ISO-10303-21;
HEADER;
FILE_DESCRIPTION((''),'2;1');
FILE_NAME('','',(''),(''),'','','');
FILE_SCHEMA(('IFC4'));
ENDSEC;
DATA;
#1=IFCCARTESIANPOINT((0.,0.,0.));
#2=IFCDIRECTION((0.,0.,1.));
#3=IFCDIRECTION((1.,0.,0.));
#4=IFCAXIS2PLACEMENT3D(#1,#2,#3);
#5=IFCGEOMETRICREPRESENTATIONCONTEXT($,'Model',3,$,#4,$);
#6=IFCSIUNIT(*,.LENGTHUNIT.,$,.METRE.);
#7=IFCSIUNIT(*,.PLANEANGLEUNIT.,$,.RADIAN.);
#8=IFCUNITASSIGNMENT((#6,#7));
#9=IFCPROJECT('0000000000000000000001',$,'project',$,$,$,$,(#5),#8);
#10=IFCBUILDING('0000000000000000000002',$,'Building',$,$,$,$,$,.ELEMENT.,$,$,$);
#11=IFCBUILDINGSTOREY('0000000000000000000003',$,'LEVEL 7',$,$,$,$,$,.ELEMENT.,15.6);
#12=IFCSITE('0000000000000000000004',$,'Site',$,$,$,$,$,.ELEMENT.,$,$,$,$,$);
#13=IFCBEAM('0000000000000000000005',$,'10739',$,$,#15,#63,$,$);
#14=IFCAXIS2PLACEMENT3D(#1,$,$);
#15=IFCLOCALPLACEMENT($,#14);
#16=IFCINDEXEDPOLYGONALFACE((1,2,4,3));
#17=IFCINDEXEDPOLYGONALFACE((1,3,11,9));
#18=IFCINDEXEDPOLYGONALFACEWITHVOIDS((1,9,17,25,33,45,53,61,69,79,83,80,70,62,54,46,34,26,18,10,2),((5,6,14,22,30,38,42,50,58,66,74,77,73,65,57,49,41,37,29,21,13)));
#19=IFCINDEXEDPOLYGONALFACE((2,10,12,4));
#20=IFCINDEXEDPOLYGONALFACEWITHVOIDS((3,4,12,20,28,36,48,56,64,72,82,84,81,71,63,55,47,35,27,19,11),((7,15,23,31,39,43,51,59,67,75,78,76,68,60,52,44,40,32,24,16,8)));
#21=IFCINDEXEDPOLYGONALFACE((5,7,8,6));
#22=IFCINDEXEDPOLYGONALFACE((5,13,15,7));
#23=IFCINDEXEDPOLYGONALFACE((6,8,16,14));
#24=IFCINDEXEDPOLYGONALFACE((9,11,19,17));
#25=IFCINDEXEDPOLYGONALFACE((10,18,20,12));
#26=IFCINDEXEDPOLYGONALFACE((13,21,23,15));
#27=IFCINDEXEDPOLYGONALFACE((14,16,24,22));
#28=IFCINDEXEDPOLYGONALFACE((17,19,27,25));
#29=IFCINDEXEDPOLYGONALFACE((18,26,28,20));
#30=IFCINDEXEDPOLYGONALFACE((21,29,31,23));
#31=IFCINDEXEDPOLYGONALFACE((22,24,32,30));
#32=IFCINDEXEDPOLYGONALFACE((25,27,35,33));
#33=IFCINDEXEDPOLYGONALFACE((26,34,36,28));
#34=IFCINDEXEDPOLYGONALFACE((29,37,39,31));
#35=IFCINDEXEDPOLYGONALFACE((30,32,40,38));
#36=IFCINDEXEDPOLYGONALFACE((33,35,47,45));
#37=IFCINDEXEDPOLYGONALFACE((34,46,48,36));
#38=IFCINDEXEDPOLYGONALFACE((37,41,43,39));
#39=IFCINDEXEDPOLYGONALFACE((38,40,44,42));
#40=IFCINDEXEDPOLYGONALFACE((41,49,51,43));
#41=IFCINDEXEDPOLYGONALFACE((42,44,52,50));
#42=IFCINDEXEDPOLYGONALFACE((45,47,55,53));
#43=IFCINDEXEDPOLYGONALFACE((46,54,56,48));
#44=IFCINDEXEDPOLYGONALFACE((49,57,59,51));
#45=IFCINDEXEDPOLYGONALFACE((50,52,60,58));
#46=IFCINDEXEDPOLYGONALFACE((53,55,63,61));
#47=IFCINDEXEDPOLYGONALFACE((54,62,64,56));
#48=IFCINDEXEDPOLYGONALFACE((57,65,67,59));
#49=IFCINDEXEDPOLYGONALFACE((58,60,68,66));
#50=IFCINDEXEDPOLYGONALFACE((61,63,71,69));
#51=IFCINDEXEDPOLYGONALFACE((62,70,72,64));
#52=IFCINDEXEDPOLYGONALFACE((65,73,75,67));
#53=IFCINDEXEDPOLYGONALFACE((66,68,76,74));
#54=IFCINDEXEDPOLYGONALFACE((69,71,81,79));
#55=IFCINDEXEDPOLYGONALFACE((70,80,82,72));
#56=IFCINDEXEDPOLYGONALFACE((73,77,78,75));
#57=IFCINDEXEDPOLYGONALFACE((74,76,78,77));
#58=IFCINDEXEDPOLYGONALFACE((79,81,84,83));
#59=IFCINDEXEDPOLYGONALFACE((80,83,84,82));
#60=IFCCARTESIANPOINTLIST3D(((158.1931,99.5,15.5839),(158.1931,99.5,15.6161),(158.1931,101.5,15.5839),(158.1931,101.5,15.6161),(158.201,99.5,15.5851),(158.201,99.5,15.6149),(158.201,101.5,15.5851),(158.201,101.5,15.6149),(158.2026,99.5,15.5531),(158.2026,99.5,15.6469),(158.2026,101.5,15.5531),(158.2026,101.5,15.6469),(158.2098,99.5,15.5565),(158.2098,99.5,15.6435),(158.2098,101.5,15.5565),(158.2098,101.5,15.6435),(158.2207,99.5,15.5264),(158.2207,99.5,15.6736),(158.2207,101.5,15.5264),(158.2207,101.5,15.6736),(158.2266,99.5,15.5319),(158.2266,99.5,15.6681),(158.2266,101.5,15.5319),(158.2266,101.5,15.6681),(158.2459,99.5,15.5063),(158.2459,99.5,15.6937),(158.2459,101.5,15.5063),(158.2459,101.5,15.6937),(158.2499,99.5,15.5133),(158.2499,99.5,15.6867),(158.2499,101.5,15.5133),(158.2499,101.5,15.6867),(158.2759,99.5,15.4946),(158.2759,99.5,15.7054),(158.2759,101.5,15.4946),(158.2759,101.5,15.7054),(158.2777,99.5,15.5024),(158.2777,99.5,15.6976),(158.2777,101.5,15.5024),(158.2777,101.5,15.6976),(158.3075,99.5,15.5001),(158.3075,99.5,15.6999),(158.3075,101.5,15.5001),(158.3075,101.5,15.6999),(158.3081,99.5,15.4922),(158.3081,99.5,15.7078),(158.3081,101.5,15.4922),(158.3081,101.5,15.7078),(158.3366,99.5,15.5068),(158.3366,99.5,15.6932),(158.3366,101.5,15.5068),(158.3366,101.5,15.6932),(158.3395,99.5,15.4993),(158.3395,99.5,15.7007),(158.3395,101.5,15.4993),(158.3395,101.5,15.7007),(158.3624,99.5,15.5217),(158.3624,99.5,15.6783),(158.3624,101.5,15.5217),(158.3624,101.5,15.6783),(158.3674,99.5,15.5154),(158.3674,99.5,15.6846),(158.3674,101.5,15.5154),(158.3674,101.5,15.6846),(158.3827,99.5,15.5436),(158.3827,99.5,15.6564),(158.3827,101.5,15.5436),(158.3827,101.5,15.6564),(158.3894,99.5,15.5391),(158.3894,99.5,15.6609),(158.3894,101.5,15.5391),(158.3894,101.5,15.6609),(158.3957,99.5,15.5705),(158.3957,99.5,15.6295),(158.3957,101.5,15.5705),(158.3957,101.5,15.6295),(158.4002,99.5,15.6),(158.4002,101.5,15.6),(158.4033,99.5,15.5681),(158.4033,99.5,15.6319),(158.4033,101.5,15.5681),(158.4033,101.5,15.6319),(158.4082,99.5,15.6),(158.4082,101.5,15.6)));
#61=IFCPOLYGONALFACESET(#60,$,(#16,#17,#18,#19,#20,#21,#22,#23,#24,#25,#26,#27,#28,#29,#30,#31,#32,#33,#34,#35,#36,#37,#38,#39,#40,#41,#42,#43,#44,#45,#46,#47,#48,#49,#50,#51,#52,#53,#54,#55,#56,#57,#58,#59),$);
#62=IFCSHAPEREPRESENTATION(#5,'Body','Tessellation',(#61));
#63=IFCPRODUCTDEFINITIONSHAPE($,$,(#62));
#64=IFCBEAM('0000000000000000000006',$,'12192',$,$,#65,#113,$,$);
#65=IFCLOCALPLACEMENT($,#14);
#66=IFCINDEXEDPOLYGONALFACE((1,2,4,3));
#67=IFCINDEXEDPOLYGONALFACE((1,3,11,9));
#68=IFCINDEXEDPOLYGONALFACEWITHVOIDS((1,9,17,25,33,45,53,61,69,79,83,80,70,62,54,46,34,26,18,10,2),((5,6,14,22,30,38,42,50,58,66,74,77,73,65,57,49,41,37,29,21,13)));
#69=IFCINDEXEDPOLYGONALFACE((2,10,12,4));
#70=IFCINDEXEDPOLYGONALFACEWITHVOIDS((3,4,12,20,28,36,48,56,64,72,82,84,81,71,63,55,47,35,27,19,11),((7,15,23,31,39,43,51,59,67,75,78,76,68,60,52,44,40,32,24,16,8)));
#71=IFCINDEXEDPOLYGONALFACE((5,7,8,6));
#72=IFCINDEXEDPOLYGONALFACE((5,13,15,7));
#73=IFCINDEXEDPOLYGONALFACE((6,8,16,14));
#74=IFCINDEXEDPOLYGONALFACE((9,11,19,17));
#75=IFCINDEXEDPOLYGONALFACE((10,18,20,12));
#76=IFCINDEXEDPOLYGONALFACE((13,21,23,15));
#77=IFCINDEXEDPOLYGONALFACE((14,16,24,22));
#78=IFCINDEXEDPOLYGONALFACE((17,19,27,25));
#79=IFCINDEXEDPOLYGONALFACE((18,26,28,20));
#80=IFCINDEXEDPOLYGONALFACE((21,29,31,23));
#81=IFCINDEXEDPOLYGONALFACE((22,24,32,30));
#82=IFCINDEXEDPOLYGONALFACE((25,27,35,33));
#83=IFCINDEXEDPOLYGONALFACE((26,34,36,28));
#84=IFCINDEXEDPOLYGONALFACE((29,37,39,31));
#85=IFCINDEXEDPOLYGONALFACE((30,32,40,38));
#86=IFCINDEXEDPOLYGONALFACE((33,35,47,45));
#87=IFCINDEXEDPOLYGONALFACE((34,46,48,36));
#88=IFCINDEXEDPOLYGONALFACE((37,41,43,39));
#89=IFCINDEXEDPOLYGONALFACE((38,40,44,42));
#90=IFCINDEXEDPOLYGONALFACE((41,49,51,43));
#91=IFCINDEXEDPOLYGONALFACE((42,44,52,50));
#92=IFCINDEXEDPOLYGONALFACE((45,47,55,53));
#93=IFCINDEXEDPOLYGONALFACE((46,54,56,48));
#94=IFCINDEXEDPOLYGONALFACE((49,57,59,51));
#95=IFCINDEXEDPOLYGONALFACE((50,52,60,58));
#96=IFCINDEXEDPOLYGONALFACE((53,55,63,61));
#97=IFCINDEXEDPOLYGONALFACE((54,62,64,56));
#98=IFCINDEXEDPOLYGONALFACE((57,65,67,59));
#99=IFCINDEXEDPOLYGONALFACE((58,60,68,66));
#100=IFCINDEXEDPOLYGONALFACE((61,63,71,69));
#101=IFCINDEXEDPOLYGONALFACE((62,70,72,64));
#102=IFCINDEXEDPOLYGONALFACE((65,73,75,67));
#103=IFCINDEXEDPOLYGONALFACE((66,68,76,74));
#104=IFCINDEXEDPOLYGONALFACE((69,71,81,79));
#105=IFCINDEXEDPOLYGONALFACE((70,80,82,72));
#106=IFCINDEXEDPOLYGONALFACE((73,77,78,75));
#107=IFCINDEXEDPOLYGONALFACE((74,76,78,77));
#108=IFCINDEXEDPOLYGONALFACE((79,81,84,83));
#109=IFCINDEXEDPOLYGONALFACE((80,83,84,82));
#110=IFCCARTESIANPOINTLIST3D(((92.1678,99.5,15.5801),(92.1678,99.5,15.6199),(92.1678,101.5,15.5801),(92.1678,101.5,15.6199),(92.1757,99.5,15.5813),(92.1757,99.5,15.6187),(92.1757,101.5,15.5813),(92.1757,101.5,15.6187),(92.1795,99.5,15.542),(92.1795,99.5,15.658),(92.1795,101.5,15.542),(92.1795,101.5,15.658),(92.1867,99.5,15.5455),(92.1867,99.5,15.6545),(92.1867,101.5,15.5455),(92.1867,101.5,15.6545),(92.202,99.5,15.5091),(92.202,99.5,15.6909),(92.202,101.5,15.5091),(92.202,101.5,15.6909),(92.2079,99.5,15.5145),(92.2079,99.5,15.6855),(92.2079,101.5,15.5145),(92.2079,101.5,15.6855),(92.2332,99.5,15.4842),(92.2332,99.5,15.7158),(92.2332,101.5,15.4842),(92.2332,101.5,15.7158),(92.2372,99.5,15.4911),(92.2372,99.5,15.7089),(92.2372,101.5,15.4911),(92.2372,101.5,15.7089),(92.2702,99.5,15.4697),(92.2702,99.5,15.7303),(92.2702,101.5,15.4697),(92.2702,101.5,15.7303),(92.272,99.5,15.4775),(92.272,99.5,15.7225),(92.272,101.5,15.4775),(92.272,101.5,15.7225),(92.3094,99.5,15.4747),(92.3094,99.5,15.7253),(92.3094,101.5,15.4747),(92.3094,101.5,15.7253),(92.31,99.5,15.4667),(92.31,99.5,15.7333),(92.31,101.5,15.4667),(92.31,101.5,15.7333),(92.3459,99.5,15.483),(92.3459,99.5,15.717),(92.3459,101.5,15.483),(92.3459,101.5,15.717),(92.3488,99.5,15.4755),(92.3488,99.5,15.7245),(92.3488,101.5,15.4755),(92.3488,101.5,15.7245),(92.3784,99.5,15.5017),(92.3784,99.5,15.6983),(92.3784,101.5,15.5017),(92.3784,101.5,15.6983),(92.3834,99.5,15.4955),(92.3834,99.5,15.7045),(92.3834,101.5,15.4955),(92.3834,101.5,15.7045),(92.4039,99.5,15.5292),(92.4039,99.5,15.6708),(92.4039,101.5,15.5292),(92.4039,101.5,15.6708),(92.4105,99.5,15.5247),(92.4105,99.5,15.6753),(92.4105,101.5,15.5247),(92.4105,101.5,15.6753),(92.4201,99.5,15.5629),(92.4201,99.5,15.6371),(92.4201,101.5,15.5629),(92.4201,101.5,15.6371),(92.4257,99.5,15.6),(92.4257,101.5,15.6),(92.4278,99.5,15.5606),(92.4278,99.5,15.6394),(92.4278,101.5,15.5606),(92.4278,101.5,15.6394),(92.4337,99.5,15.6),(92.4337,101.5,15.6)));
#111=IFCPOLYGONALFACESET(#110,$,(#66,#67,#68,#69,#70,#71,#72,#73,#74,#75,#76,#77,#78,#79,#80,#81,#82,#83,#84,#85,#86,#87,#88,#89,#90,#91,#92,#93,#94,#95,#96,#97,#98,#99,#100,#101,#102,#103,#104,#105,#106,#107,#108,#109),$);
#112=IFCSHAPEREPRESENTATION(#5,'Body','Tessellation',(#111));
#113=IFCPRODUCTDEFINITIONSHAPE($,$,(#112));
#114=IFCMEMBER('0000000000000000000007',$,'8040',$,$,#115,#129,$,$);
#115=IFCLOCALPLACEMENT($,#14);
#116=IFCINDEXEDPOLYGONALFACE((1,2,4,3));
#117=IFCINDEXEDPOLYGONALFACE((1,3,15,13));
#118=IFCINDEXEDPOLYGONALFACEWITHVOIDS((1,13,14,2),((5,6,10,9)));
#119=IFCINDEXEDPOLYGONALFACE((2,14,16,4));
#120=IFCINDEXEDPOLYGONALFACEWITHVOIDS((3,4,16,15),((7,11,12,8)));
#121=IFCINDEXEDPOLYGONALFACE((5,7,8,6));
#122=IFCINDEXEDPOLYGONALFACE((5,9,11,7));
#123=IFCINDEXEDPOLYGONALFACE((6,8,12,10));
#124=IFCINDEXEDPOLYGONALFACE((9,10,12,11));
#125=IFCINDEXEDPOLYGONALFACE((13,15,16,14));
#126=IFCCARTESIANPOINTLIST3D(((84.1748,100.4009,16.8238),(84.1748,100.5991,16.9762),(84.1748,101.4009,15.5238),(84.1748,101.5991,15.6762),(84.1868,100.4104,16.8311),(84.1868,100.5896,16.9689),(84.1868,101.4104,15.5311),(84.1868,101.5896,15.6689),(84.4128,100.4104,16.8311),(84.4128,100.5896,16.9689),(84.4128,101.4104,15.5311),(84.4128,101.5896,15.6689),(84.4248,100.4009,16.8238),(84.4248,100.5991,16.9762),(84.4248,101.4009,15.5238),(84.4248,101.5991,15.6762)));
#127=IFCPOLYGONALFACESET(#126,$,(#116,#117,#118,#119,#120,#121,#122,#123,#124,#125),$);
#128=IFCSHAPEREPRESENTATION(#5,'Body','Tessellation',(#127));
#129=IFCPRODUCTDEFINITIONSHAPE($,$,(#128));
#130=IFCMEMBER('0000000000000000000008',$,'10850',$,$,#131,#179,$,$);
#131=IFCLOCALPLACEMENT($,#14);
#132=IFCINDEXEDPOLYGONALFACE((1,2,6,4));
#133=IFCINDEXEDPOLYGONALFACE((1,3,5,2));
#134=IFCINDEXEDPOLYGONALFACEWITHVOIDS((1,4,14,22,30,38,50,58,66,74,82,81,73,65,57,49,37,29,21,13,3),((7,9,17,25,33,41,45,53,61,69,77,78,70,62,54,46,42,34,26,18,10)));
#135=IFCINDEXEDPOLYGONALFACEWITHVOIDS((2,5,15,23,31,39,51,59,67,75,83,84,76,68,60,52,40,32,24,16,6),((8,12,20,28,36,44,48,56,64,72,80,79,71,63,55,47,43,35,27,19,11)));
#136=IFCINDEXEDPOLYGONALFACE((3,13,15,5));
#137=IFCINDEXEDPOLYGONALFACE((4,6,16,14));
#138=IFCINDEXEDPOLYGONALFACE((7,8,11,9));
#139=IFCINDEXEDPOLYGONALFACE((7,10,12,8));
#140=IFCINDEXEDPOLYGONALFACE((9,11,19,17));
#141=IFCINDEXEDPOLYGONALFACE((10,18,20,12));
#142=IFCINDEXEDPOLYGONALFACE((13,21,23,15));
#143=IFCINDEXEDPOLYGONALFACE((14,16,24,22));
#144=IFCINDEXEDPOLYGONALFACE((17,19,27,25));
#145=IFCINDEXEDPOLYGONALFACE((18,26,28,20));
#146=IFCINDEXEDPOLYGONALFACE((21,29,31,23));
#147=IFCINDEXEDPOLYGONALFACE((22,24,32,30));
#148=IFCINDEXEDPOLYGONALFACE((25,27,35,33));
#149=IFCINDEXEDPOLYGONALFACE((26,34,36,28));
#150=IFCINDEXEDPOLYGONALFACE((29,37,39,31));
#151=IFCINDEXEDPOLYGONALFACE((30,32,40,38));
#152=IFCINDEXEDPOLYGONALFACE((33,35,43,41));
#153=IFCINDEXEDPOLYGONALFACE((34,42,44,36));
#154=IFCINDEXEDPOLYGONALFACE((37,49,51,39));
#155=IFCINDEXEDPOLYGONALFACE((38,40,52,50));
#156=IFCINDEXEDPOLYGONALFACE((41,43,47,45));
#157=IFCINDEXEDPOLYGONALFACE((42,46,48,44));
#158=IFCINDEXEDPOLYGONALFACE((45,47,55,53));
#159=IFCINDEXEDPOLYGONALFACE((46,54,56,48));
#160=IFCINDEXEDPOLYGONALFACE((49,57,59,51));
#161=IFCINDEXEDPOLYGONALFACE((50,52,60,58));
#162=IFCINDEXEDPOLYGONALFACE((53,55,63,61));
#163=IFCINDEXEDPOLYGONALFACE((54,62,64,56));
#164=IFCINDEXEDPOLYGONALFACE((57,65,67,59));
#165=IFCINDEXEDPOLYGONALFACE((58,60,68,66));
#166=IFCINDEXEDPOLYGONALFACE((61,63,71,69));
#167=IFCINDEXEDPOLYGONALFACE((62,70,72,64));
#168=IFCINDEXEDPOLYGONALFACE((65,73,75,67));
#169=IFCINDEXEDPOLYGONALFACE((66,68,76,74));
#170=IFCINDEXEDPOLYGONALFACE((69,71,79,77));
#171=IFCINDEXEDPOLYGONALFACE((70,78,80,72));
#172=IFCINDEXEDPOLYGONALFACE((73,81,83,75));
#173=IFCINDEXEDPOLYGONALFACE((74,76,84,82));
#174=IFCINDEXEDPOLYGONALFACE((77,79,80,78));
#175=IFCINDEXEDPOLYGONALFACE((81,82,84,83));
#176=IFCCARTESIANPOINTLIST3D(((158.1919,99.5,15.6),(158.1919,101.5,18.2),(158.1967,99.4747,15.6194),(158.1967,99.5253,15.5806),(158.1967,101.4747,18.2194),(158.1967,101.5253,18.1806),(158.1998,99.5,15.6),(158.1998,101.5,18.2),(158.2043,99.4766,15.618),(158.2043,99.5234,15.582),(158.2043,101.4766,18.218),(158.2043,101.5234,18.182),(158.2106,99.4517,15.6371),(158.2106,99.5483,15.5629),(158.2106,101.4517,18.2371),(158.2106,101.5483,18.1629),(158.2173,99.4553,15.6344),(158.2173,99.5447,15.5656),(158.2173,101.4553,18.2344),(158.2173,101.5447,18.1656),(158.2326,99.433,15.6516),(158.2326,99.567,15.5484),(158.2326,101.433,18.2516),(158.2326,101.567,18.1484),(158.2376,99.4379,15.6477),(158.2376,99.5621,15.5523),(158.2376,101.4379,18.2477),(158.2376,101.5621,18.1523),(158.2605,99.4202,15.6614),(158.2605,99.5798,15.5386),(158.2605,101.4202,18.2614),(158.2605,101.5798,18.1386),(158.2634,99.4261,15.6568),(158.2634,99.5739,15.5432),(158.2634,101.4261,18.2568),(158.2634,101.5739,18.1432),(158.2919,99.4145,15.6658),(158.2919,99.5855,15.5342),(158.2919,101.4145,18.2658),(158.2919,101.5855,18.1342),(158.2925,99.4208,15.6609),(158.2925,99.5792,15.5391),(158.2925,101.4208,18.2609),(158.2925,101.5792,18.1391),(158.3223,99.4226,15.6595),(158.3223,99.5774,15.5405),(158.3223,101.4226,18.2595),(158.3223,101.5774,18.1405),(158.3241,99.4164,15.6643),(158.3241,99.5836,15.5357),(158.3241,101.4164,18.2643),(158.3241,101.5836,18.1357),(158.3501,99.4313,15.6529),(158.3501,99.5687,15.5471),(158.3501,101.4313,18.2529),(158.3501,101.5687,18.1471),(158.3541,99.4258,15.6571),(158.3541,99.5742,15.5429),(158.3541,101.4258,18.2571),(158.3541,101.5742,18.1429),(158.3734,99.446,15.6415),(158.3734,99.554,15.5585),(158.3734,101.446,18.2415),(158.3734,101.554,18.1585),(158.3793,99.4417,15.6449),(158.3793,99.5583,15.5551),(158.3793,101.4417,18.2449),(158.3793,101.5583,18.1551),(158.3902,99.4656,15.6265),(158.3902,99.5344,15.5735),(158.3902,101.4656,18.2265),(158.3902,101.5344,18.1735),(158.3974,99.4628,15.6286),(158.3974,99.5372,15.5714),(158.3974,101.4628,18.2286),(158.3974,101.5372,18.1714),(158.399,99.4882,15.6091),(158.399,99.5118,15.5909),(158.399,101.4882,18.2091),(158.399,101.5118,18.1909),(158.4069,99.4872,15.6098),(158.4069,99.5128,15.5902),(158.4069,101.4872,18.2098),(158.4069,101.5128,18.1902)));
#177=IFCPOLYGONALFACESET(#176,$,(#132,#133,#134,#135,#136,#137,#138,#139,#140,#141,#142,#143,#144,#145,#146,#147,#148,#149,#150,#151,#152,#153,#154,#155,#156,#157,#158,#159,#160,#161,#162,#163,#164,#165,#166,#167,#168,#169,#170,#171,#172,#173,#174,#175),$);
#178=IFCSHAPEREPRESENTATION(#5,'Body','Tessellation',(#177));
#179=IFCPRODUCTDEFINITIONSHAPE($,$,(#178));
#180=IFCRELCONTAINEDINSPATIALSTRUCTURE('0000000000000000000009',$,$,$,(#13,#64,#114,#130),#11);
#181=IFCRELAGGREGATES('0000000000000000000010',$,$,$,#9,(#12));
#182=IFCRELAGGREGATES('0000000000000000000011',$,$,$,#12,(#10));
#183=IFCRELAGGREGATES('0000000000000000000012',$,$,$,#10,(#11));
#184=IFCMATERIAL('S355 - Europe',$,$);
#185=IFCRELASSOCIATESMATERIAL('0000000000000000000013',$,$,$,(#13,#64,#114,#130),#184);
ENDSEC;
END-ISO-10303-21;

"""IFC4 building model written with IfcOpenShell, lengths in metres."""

from ifc_helpers import new_model, si_unit, frame, origin_with_axes, origin_2d_with_axis, place, context, project, spatial, hollow_rectangle, hollow_circle, extrude, material, material_profile, profile_set, profile_usage, element, save


model = new_model("IFC4")

# Units and contexts
model_context = context("Model", 3, world=origin_with_axes())
ifc_project = project(units=[si_unit("LENGTHUNIT", "METRE"), si_unit("PLANEANGLEUNIT", "RADIAN")], contexts=[model_context])

# Site, building, storey
site = spatial("IfcSite", under=ifc_project, Name="Site", CompositionType="ELEMENT")
building = spatial("IfcBuilding", under=site, Name="Building", CompositionType="ELEMENT")
storey = spatial("IfcBuildingStorey", under=building, Name="LEVEL 7", CompositionType="ELEMENT", Elevation=15.6)

# Shared definitions
ifc_material = material(Name="S355 - Europe")

# Beams
ifc_material_profile_1 = material_profile(ifc_material, hollow_circle(Radius=0.1081, WallThickness=0.008, at=origin_2d_with_axis()))
ifc_profile_set_1 = profile_set([ifc_material_profile_1])
ifc_profile_usage_1 = profile_usage(ifc_profile_set_1, cardinal=10)
beam_1_placement = place(None, frame((158.3, 101.5, 15.6), z_axis=(0.0, -1.0, 0.0), x_axis=(1.0, 0.0, 0.0)))
element("IfcBeam", 1, at=beam_1_placement, inside=storey, material=ifc_profile_usage_1, Name="10739", context=model_context, shape_type="SweptSolid", body=[
    extrude(hollow_circle(Radius=0.1081, WallThickness=0.008, at=origin_2d_with_axis()), origin_with_axes(), (0.0, 0.0, 1.0), 2.0),
])
ifc_material_profile_2 = material_profile(ifc_material, hollow_circle(Radius=0.1337, WallThickness=0.008, at=origin_2d_with_axis()))
ifc_profile_set_2 = profile_set([ifc_material_profile_2])
ifc_profile_usage_2 = profile_usage(ifc_profile_set_2, cardinal=10)
beam_2_placement = place(None, frame((92.3, 101.5, 15.6), z_axis=(0.0, -1.0, 0.0), x_axis=(1.0, 0.0, 0.0)))
element("IfcBeam", 2, at=beam_2_placement, inside=storey, material=ifc_profile_usage_2, Name="12192", context=model_context, shape_type="SweptSolid", body=[
    extrude(hollow_circle(Radius=0.1337, WallThickness=0.008, at=origin_2d_with_axis()), origin_with_axes(), (0.0, 0.0, 1.0), 2.0),
])

# Members
ifc_material_profile_3 = material_profile(ifc_material, hollow_rectangle(XDim=0.25, YDim=0.25, WallThickness=0.012, at=origin_2d_with_axis()))
ifc_profile_set_3 = profile_set([ifc_material_profile_3])
ifc_profile_usage_3 = profile_usage(ifc_profile_set_3, cardinal=10)
member_1_placement = place(None, frame((84.2998, 100.5, 16.9), z_axis=(0.0, 0.609711, -0.792624), x_axis=(-1.0, 0.0, 0.0)))
element("IfcMember", 3, at=member_1_placement, inside=storey, material=ifc_profile_usage_3, Name="8040", context=model_context, shape_type="SweptSolid", body=[
    extrude(hollow_rectangle(XDim=0.25, YDim=0.25, WallThickness=0.012, at=origin_2d_with_axis()), origin_with_axes(), (0.0, 0.0, 1.0), 1.6401),
])
ifc_material_profile_4 = material_profile(ifc_material, hollow_circle(Radius=0.1081, WallThickness=0.008, at=origin_2d_with_axis()))
ifc_profile_set_4 = profile_set([ifc_material_profile_4])
ifc_profile_usage_4 = profile_usage(ifc_profile_set_4, cardinal=10)
member_2_placement = place(None, frame((158.3, 99.5, 15.6), z_axis=(0.0, 0.609711, 0.792624), x_axis=(-1.0, 0.0, 0.0)))
element("IfcMember", 4, at=member_2_placement, inside=storey, material=ifc_profile_usage_4, Name="10850", context=model_context, shape_type="SweptSolid", body=[
    extrude(hollow_circle(Radius=0.1081, WallThickness=0.008, at=origin_2d_with_axis()), origin_with_axes(), (0.0, 0.0, 1.0), 3.2802),
])

save(model, "model.ifc")
